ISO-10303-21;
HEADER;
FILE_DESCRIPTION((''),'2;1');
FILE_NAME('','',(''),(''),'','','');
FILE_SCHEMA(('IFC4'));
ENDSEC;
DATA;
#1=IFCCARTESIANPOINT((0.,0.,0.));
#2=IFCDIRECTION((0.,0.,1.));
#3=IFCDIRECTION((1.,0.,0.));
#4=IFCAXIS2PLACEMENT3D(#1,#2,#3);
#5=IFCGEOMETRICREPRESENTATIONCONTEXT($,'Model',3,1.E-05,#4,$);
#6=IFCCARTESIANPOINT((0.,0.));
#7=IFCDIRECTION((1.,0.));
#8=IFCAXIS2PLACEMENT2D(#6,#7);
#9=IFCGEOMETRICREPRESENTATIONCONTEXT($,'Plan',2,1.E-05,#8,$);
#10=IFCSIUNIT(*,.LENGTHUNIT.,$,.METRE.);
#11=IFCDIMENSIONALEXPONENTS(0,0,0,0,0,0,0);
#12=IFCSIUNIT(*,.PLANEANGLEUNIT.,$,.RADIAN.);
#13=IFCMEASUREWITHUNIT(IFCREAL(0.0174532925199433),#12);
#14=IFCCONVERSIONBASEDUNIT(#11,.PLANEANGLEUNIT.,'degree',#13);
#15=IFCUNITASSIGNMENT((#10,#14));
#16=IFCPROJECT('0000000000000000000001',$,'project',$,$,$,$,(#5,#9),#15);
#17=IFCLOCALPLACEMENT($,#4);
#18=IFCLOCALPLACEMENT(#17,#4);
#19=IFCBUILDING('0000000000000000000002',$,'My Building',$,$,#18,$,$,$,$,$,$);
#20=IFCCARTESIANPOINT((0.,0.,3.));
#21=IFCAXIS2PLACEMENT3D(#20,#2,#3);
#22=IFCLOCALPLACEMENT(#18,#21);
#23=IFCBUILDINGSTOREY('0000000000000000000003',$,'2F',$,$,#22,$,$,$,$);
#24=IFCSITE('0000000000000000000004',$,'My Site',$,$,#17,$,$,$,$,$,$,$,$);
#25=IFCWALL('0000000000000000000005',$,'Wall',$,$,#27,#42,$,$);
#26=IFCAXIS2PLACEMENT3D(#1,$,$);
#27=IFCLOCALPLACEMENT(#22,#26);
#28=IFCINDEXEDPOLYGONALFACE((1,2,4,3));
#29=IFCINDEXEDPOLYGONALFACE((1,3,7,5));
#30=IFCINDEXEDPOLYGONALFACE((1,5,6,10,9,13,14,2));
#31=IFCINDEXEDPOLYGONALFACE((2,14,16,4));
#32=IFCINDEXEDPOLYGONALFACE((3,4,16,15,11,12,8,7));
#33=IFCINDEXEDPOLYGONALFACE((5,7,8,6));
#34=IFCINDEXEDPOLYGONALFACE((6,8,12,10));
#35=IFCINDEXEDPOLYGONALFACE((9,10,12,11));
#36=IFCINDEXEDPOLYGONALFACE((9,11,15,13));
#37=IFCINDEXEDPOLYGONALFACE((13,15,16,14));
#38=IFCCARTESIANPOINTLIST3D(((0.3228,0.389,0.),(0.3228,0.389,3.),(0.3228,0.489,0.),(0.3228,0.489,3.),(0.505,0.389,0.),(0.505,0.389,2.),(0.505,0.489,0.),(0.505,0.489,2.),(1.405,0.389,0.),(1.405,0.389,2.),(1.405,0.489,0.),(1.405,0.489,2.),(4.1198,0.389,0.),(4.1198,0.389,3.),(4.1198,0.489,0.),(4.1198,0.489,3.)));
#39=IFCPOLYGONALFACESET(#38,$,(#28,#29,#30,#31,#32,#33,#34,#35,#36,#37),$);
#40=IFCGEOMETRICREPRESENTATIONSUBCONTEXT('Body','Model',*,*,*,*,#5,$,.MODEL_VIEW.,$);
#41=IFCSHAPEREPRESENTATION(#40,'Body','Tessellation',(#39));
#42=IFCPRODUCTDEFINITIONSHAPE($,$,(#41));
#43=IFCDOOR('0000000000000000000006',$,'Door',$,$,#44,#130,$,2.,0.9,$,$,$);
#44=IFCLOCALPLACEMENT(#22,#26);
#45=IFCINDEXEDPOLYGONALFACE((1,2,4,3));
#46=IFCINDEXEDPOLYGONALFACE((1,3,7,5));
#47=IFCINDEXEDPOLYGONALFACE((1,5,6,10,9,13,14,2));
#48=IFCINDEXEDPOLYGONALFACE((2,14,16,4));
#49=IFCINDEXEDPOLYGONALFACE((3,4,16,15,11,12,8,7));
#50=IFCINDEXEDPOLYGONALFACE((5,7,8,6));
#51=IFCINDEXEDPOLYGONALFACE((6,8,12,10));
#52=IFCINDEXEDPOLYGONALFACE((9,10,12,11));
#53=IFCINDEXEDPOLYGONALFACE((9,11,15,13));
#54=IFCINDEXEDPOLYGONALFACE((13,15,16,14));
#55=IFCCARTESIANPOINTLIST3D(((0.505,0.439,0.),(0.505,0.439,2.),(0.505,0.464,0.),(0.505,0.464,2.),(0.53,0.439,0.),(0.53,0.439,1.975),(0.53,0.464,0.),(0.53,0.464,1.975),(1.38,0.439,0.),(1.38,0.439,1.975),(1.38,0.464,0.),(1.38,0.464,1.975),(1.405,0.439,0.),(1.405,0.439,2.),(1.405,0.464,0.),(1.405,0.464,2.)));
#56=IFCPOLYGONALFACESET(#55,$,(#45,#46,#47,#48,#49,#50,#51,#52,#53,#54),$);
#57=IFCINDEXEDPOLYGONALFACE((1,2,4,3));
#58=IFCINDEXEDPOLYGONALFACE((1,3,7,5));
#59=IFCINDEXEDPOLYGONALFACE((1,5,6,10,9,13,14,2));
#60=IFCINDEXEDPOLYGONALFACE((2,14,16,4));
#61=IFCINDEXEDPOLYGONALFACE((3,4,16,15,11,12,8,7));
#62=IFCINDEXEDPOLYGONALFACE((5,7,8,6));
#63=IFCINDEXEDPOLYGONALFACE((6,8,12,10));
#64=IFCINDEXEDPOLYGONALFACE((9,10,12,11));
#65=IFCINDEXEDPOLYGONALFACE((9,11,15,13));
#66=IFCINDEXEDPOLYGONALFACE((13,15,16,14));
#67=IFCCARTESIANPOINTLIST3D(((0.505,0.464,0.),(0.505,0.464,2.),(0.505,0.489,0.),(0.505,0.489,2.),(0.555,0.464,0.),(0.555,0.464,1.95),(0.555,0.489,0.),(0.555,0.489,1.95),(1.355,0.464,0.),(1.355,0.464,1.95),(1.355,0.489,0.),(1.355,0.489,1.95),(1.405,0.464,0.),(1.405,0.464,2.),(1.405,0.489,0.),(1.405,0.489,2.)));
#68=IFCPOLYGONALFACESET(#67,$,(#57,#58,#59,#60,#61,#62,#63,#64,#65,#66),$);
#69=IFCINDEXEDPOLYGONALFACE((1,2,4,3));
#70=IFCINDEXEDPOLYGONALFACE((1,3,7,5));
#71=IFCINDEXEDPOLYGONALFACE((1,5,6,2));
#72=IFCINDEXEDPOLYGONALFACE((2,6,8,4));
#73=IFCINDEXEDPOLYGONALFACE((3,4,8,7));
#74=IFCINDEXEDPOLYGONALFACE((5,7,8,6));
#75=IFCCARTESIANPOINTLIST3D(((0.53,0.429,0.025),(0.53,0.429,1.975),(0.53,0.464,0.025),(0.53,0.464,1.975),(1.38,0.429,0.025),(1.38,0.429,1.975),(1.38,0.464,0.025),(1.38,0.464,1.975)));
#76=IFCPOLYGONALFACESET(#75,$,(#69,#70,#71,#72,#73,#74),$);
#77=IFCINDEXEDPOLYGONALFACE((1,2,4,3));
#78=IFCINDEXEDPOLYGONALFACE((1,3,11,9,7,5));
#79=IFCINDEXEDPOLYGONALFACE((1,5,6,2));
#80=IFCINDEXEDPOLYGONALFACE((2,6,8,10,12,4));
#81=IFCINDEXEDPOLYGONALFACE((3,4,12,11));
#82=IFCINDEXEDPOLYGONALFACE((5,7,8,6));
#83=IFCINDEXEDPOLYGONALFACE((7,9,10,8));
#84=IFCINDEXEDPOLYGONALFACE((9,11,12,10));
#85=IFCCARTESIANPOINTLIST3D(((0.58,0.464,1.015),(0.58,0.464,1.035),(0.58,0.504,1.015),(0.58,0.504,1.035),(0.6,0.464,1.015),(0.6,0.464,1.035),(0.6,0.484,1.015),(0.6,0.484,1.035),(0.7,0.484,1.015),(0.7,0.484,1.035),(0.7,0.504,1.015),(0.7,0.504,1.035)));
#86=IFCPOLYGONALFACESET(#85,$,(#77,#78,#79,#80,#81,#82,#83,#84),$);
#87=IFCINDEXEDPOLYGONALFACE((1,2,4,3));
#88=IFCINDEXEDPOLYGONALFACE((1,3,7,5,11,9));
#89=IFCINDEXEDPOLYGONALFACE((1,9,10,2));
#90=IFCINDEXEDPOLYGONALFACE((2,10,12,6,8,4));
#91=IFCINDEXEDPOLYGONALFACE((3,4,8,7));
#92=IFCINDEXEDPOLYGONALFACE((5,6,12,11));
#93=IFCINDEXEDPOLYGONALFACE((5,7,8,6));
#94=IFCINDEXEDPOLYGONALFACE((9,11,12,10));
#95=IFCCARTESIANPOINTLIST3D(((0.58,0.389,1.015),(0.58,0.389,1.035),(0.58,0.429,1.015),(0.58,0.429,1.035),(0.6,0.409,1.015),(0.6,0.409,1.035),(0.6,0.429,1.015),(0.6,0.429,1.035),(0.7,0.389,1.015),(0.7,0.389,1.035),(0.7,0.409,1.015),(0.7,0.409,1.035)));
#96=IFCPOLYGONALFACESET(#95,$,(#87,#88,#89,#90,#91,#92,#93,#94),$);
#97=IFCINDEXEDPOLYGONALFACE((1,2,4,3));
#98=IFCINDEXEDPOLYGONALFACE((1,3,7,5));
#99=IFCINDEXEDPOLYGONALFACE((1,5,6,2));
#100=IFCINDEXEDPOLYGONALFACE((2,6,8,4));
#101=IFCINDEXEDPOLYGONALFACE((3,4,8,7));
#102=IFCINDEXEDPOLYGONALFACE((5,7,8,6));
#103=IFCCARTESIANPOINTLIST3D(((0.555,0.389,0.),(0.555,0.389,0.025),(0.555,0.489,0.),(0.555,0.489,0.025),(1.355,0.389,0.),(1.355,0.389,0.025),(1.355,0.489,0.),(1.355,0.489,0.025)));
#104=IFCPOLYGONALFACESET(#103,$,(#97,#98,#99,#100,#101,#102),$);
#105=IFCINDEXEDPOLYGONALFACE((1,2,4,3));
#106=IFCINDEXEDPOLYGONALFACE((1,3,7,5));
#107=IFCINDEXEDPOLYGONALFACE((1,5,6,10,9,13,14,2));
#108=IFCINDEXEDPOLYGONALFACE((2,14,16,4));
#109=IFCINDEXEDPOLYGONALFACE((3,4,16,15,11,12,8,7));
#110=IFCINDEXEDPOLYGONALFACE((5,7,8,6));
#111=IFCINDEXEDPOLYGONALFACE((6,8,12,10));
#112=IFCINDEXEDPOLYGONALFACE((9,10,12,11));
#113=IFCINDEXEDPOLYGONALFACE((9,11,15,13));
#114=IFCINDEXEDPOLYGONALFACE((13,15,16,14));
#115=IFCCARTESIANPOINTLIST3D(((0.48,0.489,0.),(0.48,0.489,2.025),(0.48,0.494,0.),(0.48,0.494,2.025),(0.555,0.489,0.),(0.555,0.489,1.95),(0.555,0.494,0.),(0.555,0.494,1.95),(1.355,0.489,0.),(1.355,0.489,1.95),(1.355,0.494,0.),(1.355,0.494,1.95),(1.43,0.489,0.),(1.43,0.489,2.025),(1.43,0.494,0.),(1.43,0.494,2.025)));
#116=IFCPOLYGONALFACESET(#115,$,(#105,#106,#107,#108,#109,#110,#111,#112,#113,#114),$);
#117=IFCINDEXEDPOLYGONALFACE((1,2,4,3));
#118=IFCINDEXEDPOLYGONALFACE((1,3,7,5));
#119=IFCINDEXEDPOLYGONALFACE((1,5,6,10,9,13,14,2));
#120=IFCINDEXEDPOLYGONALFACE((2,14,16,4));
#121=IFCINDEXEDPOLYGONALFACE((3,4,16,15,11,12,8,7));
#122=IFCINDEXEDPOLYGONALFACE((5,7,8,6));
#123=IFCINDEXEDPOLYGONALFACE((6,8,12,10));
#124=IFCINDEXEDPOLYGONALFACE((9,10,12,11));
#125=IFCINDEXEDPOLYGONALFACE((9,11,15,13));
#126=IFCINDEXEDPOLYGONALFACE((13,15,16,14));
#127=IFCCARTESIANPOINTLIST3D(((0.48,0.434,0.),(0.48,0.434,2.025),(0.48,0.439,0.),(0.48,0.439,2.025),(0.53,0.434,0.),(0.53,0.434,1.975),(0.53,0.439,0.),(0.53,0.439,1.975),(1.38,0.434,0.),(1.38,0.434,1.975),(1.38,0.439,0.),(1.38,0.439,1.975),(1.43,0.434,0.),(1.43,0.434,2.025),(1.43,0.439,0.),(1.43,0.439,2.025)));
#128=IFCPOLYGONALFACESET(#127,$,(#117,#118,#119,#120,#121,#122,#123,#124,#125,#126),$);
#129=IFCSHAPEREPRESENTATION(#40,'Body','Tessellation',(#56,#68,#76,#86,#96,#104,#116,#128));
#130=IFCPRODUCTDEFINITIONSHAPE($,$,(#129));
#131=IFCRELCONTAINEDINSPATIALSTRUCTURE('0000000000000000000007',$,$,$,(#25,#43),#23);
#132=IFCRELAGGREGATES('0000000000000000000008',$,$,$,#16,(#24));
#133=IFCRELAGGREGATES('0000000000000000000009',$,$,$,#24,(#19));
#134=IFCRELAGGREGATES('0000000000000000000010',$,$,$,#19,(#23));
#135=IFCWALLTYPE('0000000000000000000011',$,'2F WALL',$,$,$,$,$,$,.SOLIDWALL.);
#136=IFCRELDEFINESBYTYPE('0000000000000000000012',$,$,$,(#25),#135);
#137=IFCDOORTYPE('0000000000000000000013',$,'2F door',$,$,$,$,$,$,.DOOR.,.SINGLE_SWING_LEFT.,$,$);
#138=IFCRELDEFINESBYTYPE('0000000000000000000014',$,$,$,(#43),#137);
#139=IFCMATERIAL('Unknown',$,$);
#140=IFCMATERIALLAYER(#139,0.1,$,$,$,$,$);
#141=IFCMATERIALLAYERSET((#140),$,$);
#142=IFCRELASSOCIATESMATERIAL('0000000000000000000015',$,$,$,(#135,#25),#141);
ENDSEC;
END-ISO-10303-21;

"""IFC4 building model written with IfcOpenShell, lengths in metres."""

from ifc_helpers import new_model, entity, si_unit, converted_unit, frame, origin_with_axes, origin_2d_with_axis, place, context, subcontext, project, spatial, line, indexed_curve, outline, extrude, shape, source, transform, mapped, material, layer, layer_set, layer_usage, type_object, type_shapes, element, fill, save


model = new_model("IFC4")

# Units and contexts
model_context = context("Model", 3, precision=1e-05, world=origin_with_axes())
plan_context = context("Plan", 2, precision=1e-05, world=origin_2d_with_axis())
body_context_1 = subcontext(model_context, "Body", "Model", "MODEL_VIEW")
body_context_2 = subcontext(plan_context, "Body", "Plan", "PLAN_VIEW")
ifc_project = project(units=[si_unit("LENGTHUNIT", "METRE"), converted_unit("PLANEANGLEUNIT", "degree", entity("IfcReal", 0.0174532925199433), si_unit("PLANEANGLEUNIT", "RADIAN"), dimensions=[0, 0, 0, 0, 0, 0, 0])], contexts=[model_context, plan_context])

# Site, building, storey
site_placement = place(None, origin_with_axes())
site = spatial("IfcSite", under=ifc_project, at=site_placement, Name="My Site")
building_placement = place(site_placement, origin_with_axes())
building = spatial("IfcBuilding", under=site, at=building_placement, Name="My Building")
storey_placement = place(building_placement, frame((0.0, 0.0, 3.0), z_axis=(0.0, 0.0, 1.0), x_axis=(1.0, 0.0, 0.0)))
storey = spatial("IfcBuildingStorey", under=building, at=storey_placement, Name="2F")

# Shared definitions
ifc_material = material(Name="Unknown")

# Shared definitions
ifc_layer_1 = layer(ifc_material, 0.1)
ifc_layer_set_1 = layer_set([ifc_layer_1])
wall_type = type_object("IfcWallType", Name="2F WALL", PredefinedType="SOLIDWALL", material=ifc_layer_set_1)

# Wall, opening, door
shared_shape_1 = source(origin_with_axes(), body_context_1, "Body", "SweptSolid", [
    extrude(outline(indexed_curve([(0.0, 0.0), (0.9, 0.0), (0.9, 2.0), (0.0, 2.0)], segments=[line(1, 2, 3, 4, 1)])), frame((0.0, -0.6, 0.0), z_axis=(0.0, -1.0, 0.0), x_axis=(1.0, 0.0, 0.0)), (0.0, 0.0, -1.0), 1.2),
])
door_type = type_object("IfcDoorType", Name="2F door", OperationType="SINGLE_SWING_LEFT", PredefinedType="DOOR")
shared_shape_2 = source(origin_with_axes(), body_context_1, "Body", "SweptSolid", [
    extrude(outline(indexed_curve([(0.0, 0.0), (0.0, 2.0), (0.9, 2.0), (0.9, 0.0), (0.875, 0.0), (0.875, 1.975), (0.025, 1.975), (0.025, 0.0)], segments=[line(1, 2, 3, 4, 5, 6, 7, 8, 1)])), frame((0.0, 0.025, 0.0), z_axis=(0.0, -1.0, 0.0), x_axis=(1.0, 0.0, 0.0)), (0.0, 0.0, -1.0), 0.025),
    extrude(outline(indexed_curve([(0.0, 0.0), (0.0, 2.0), (0.9, 2.0), (0.9, 0.0), (0.85, 0.0), (0.85, 1.95), (0.05, 1.95), (0.05, 0.0)], segments=[line(1, 2, 3, 4, 5, 6, 7, 8, 1)])), frame((0.0, 0.0, 0.0), z_axis=(0.0, -1.0, 0.0), x_axis=(1.0, 0.0, 0.0)), (0.0, 0.0, -1.0), 0.025),
    extrude(outline(indexed_curve([(0.0, 0.0), (0.85, 0.0), (0.85, 0.035), (0.0, 0.035)], segments=[line(1, 2, 3, 4, 1)])), frame((0.025, 0.025, 0.025), z_axis=(0.0, 0.0, 1.0), x_axis=(1.0, 0.0, 0.0)), (0.0, 0.0, 1.0), 1.95),
    extrude(outline(indexed_curve([(0.0, 0.0), (0.0, -0.04), (-0.12, -0.04), (-0.12, -0.02), (-0.02, -0.02), (-0.02, 0.0)], segments=[line(1, 2, 3, 4, 5, 6, 1)])), frame((0.825, 0.025, 1.015), z_axis=(0.0, 0.0, 1.0), x_axis=(1.0, 0.0, 0.0)), (0.0, 0.0, 1.0), 0.02),
    extrude(outline(indexed_curve([(0.0, 0.0), (0.0, 0.04), (-0.12, 0.04), (-0.12, 0.02), (-0.02, 0.02), (-0.02, 0.0)], segments=[line(1, 2, 3, 4, 5, 6, 1)])), frame((0.825, 0.06, 1.015), z_axis=(0.0, 0.0, 1.0), x_axis=(1.0, 0.0, 0.0)), (0.0, 0.0, 1.0), 0.02),
    extrude(outline(indexed_curve([(0.0, 0.0), (0.8, 0.0), (0.8, 0.1), (0.0, 0.1)], segments=[line(1, 2, 3, 4, 1)])), frame((0.05, 0.0, 0.0), z_axis=(0.0, 0.0, 1.0), x_axis=(1.0, 0.0, 0.0)), (0.0, 0.0, 1.0), 0.025),
    extrude(outline(indexed_curve([(0.0, 0.0), (0.0, 2.025), (0.95, 2.025), (0.95, 0.0), (0.875, 0.0), (0.875, 1.95), (0.075, 1.95), (0.075, 0.0)], segments=[line(1, 2, 3, 4, 5, 6, 7, 8, 1)])), frame((-0.025, -0.005, 0.0), z_axis=(0.0, -1.0, 0.0), x_axis=(1.0, 0.0, 0.0)), (0.0, 0.0, -1.0), 0.005),
    extrude(outline(indexed_curve([(0.0, 0.0), (0.0, 2.025), (0.95, 2.025), (0.95, 0.0), (0.9, 0.0), (0.9, 1.975), (0.05, 1.975), (0.05, 0.0)], segments=[line(1, 2, 3, 4, 5, 6, 7, 8, 1)])), frame((-0.025, 0.05, 0.0), z_axis=(0.0, -1.0, 0.0), x_axis=(1.0, 0.0, 0.0)), (0.0, 0.0, -1.0), 0.005),
])
shared_shape_3 = source(origin_with_axes(), body_context_2, "Body", "Curve2D", [
    entity("IfcIndexedPolyCurve", entity("IfcCartesianPointList2D", [[0.0, 0.0], [0.0, 0.05], [0.025, 0.05], [0.025, 0.025], [0.05, 0.025], [0.05, 0.0]]), [entity("IfcLineIndex", [1, 2, 3, 4, 5, 6, 1])]),
    entity("IfcIndexedPolyCurve", entity("IfcCartesianPointList2D", [[0.9, 0.0], [0.9, 0.05], [0.875, 0.05], [0.875, 0.025], [0.85, 0.025], [0.85, 0.0]]), [entity("IfcLineIndex", [1, 2, 3, 4, 5, 6, 1])]),
    entity("IfcTrimmedCurve", entity("IfcEllipse", entity("IfcAxis2Placement2D", entity("IfcCartesianPoint", [0.06, 0.05]), entity("IfcDirection", [1.0, 0.0])), 0.815, 0.85), [entity("IfcCartesianPoint", [0.875, 0.05])], [entity("IfcCartesianPoint", [0.06, 0.9])], True, "CARTESIAN"),
    entity("IfcIndexedPolyCurve", entity("IfcCartesianPointList2D", [[0.025, 0.05], [0.06, 0.05], [0.06, 0.9], [0.025, 0.9]]), [entity("IfcLineIndex", [1, 2, 3, 4, 1])]),
])
type_shapes(door_type, [shared_shape_2, shared_shape_3])
ifc_layer_usage_1 = layer_usage(ifc_layer_set_1, "AXIS2", "POSITIVE", 0.0)
wall_1_placement = place(storey_placement, frame((4.1198, 0.489, 0.0), z_axis=(0.0, 0.0, 1.0), x_axis=(-1.0, 0.0, 0.0)))
wall_1 = element("IfcWall", 1, at=wall_1_placement, inside=storey, type_object=wall_type, material=ifc_layer_usage_1, Name="Wall", context=body_context_1, shape_type="SweptSolid", body=[
    extrude(outline(indexed_curve([(0.0, 0.0), (0.0, 0.1), (3.797, 0.1), (3.797, 0.0)], segments=[line(1, 2, 3, 4, 1)])), origin_with_axes(), (0.0, 0.0, 1.0), 3.0),
])
opening_1_placement = place(wall_1_placement, frame((2.7148, 0.0, 0.0), z_axis=(0.0, 0.0, 1.0), x_axis=(1.0, 0.0, 0.0)))
opening_1 = element("IfcOpeningElement", 2, at=opening_1_placement, cuts=wall_1, PredefinedType="OPENING", context=body_context_1, shape_type="MappedRepresentation", body=[
    mapped(shared_shape_1, transform((0.0, 0.0, 0.0), x_axis=(1.0, 0.0, 0.0), y_axis=(0.0, 1.0, 0.0), z_axis=(0.0, 0.0, 1.0), scale=1.0)),
])
door_1_placement = place(opening_1_placement, frame((0.0, 0.0, 0.0), z_axis=(0.0, 0.0, 1.0), x_axis=(1.0, 0.0, 0.0)))
door_1 = element("IfcDoor", 3, at=door_1_placement, inside=storey, type_object=door_type, Name="Door", OverallHeight=2.0, OverallWidth=0.9, shapes=[
    shape(body_context_1, "Body", "MappedRepresentation", [mapped(shared_shape_2, transform((0.0, 0.0, 0.0), x_axis=(1.0, 0.0, 0.0), y_axis=(0.0, 1.0, 0.0), z_axis=(0.0, 0.0, 1.0), scale=1.0))]),
    shape(body_context_2, "Body", "MappedRepresentation", [mapped(shared_shape_3, transform((0.0, 0.0, 0.0), x_axis=(1.0, 0.0, 0.0), y_axis=(0.0, 1.0, 0.0), z_axis=(0.0, 0.0, 1.0), scale=1.0))]),
])
fill(opening_1, door_1)

save(model, "model.ifc")
